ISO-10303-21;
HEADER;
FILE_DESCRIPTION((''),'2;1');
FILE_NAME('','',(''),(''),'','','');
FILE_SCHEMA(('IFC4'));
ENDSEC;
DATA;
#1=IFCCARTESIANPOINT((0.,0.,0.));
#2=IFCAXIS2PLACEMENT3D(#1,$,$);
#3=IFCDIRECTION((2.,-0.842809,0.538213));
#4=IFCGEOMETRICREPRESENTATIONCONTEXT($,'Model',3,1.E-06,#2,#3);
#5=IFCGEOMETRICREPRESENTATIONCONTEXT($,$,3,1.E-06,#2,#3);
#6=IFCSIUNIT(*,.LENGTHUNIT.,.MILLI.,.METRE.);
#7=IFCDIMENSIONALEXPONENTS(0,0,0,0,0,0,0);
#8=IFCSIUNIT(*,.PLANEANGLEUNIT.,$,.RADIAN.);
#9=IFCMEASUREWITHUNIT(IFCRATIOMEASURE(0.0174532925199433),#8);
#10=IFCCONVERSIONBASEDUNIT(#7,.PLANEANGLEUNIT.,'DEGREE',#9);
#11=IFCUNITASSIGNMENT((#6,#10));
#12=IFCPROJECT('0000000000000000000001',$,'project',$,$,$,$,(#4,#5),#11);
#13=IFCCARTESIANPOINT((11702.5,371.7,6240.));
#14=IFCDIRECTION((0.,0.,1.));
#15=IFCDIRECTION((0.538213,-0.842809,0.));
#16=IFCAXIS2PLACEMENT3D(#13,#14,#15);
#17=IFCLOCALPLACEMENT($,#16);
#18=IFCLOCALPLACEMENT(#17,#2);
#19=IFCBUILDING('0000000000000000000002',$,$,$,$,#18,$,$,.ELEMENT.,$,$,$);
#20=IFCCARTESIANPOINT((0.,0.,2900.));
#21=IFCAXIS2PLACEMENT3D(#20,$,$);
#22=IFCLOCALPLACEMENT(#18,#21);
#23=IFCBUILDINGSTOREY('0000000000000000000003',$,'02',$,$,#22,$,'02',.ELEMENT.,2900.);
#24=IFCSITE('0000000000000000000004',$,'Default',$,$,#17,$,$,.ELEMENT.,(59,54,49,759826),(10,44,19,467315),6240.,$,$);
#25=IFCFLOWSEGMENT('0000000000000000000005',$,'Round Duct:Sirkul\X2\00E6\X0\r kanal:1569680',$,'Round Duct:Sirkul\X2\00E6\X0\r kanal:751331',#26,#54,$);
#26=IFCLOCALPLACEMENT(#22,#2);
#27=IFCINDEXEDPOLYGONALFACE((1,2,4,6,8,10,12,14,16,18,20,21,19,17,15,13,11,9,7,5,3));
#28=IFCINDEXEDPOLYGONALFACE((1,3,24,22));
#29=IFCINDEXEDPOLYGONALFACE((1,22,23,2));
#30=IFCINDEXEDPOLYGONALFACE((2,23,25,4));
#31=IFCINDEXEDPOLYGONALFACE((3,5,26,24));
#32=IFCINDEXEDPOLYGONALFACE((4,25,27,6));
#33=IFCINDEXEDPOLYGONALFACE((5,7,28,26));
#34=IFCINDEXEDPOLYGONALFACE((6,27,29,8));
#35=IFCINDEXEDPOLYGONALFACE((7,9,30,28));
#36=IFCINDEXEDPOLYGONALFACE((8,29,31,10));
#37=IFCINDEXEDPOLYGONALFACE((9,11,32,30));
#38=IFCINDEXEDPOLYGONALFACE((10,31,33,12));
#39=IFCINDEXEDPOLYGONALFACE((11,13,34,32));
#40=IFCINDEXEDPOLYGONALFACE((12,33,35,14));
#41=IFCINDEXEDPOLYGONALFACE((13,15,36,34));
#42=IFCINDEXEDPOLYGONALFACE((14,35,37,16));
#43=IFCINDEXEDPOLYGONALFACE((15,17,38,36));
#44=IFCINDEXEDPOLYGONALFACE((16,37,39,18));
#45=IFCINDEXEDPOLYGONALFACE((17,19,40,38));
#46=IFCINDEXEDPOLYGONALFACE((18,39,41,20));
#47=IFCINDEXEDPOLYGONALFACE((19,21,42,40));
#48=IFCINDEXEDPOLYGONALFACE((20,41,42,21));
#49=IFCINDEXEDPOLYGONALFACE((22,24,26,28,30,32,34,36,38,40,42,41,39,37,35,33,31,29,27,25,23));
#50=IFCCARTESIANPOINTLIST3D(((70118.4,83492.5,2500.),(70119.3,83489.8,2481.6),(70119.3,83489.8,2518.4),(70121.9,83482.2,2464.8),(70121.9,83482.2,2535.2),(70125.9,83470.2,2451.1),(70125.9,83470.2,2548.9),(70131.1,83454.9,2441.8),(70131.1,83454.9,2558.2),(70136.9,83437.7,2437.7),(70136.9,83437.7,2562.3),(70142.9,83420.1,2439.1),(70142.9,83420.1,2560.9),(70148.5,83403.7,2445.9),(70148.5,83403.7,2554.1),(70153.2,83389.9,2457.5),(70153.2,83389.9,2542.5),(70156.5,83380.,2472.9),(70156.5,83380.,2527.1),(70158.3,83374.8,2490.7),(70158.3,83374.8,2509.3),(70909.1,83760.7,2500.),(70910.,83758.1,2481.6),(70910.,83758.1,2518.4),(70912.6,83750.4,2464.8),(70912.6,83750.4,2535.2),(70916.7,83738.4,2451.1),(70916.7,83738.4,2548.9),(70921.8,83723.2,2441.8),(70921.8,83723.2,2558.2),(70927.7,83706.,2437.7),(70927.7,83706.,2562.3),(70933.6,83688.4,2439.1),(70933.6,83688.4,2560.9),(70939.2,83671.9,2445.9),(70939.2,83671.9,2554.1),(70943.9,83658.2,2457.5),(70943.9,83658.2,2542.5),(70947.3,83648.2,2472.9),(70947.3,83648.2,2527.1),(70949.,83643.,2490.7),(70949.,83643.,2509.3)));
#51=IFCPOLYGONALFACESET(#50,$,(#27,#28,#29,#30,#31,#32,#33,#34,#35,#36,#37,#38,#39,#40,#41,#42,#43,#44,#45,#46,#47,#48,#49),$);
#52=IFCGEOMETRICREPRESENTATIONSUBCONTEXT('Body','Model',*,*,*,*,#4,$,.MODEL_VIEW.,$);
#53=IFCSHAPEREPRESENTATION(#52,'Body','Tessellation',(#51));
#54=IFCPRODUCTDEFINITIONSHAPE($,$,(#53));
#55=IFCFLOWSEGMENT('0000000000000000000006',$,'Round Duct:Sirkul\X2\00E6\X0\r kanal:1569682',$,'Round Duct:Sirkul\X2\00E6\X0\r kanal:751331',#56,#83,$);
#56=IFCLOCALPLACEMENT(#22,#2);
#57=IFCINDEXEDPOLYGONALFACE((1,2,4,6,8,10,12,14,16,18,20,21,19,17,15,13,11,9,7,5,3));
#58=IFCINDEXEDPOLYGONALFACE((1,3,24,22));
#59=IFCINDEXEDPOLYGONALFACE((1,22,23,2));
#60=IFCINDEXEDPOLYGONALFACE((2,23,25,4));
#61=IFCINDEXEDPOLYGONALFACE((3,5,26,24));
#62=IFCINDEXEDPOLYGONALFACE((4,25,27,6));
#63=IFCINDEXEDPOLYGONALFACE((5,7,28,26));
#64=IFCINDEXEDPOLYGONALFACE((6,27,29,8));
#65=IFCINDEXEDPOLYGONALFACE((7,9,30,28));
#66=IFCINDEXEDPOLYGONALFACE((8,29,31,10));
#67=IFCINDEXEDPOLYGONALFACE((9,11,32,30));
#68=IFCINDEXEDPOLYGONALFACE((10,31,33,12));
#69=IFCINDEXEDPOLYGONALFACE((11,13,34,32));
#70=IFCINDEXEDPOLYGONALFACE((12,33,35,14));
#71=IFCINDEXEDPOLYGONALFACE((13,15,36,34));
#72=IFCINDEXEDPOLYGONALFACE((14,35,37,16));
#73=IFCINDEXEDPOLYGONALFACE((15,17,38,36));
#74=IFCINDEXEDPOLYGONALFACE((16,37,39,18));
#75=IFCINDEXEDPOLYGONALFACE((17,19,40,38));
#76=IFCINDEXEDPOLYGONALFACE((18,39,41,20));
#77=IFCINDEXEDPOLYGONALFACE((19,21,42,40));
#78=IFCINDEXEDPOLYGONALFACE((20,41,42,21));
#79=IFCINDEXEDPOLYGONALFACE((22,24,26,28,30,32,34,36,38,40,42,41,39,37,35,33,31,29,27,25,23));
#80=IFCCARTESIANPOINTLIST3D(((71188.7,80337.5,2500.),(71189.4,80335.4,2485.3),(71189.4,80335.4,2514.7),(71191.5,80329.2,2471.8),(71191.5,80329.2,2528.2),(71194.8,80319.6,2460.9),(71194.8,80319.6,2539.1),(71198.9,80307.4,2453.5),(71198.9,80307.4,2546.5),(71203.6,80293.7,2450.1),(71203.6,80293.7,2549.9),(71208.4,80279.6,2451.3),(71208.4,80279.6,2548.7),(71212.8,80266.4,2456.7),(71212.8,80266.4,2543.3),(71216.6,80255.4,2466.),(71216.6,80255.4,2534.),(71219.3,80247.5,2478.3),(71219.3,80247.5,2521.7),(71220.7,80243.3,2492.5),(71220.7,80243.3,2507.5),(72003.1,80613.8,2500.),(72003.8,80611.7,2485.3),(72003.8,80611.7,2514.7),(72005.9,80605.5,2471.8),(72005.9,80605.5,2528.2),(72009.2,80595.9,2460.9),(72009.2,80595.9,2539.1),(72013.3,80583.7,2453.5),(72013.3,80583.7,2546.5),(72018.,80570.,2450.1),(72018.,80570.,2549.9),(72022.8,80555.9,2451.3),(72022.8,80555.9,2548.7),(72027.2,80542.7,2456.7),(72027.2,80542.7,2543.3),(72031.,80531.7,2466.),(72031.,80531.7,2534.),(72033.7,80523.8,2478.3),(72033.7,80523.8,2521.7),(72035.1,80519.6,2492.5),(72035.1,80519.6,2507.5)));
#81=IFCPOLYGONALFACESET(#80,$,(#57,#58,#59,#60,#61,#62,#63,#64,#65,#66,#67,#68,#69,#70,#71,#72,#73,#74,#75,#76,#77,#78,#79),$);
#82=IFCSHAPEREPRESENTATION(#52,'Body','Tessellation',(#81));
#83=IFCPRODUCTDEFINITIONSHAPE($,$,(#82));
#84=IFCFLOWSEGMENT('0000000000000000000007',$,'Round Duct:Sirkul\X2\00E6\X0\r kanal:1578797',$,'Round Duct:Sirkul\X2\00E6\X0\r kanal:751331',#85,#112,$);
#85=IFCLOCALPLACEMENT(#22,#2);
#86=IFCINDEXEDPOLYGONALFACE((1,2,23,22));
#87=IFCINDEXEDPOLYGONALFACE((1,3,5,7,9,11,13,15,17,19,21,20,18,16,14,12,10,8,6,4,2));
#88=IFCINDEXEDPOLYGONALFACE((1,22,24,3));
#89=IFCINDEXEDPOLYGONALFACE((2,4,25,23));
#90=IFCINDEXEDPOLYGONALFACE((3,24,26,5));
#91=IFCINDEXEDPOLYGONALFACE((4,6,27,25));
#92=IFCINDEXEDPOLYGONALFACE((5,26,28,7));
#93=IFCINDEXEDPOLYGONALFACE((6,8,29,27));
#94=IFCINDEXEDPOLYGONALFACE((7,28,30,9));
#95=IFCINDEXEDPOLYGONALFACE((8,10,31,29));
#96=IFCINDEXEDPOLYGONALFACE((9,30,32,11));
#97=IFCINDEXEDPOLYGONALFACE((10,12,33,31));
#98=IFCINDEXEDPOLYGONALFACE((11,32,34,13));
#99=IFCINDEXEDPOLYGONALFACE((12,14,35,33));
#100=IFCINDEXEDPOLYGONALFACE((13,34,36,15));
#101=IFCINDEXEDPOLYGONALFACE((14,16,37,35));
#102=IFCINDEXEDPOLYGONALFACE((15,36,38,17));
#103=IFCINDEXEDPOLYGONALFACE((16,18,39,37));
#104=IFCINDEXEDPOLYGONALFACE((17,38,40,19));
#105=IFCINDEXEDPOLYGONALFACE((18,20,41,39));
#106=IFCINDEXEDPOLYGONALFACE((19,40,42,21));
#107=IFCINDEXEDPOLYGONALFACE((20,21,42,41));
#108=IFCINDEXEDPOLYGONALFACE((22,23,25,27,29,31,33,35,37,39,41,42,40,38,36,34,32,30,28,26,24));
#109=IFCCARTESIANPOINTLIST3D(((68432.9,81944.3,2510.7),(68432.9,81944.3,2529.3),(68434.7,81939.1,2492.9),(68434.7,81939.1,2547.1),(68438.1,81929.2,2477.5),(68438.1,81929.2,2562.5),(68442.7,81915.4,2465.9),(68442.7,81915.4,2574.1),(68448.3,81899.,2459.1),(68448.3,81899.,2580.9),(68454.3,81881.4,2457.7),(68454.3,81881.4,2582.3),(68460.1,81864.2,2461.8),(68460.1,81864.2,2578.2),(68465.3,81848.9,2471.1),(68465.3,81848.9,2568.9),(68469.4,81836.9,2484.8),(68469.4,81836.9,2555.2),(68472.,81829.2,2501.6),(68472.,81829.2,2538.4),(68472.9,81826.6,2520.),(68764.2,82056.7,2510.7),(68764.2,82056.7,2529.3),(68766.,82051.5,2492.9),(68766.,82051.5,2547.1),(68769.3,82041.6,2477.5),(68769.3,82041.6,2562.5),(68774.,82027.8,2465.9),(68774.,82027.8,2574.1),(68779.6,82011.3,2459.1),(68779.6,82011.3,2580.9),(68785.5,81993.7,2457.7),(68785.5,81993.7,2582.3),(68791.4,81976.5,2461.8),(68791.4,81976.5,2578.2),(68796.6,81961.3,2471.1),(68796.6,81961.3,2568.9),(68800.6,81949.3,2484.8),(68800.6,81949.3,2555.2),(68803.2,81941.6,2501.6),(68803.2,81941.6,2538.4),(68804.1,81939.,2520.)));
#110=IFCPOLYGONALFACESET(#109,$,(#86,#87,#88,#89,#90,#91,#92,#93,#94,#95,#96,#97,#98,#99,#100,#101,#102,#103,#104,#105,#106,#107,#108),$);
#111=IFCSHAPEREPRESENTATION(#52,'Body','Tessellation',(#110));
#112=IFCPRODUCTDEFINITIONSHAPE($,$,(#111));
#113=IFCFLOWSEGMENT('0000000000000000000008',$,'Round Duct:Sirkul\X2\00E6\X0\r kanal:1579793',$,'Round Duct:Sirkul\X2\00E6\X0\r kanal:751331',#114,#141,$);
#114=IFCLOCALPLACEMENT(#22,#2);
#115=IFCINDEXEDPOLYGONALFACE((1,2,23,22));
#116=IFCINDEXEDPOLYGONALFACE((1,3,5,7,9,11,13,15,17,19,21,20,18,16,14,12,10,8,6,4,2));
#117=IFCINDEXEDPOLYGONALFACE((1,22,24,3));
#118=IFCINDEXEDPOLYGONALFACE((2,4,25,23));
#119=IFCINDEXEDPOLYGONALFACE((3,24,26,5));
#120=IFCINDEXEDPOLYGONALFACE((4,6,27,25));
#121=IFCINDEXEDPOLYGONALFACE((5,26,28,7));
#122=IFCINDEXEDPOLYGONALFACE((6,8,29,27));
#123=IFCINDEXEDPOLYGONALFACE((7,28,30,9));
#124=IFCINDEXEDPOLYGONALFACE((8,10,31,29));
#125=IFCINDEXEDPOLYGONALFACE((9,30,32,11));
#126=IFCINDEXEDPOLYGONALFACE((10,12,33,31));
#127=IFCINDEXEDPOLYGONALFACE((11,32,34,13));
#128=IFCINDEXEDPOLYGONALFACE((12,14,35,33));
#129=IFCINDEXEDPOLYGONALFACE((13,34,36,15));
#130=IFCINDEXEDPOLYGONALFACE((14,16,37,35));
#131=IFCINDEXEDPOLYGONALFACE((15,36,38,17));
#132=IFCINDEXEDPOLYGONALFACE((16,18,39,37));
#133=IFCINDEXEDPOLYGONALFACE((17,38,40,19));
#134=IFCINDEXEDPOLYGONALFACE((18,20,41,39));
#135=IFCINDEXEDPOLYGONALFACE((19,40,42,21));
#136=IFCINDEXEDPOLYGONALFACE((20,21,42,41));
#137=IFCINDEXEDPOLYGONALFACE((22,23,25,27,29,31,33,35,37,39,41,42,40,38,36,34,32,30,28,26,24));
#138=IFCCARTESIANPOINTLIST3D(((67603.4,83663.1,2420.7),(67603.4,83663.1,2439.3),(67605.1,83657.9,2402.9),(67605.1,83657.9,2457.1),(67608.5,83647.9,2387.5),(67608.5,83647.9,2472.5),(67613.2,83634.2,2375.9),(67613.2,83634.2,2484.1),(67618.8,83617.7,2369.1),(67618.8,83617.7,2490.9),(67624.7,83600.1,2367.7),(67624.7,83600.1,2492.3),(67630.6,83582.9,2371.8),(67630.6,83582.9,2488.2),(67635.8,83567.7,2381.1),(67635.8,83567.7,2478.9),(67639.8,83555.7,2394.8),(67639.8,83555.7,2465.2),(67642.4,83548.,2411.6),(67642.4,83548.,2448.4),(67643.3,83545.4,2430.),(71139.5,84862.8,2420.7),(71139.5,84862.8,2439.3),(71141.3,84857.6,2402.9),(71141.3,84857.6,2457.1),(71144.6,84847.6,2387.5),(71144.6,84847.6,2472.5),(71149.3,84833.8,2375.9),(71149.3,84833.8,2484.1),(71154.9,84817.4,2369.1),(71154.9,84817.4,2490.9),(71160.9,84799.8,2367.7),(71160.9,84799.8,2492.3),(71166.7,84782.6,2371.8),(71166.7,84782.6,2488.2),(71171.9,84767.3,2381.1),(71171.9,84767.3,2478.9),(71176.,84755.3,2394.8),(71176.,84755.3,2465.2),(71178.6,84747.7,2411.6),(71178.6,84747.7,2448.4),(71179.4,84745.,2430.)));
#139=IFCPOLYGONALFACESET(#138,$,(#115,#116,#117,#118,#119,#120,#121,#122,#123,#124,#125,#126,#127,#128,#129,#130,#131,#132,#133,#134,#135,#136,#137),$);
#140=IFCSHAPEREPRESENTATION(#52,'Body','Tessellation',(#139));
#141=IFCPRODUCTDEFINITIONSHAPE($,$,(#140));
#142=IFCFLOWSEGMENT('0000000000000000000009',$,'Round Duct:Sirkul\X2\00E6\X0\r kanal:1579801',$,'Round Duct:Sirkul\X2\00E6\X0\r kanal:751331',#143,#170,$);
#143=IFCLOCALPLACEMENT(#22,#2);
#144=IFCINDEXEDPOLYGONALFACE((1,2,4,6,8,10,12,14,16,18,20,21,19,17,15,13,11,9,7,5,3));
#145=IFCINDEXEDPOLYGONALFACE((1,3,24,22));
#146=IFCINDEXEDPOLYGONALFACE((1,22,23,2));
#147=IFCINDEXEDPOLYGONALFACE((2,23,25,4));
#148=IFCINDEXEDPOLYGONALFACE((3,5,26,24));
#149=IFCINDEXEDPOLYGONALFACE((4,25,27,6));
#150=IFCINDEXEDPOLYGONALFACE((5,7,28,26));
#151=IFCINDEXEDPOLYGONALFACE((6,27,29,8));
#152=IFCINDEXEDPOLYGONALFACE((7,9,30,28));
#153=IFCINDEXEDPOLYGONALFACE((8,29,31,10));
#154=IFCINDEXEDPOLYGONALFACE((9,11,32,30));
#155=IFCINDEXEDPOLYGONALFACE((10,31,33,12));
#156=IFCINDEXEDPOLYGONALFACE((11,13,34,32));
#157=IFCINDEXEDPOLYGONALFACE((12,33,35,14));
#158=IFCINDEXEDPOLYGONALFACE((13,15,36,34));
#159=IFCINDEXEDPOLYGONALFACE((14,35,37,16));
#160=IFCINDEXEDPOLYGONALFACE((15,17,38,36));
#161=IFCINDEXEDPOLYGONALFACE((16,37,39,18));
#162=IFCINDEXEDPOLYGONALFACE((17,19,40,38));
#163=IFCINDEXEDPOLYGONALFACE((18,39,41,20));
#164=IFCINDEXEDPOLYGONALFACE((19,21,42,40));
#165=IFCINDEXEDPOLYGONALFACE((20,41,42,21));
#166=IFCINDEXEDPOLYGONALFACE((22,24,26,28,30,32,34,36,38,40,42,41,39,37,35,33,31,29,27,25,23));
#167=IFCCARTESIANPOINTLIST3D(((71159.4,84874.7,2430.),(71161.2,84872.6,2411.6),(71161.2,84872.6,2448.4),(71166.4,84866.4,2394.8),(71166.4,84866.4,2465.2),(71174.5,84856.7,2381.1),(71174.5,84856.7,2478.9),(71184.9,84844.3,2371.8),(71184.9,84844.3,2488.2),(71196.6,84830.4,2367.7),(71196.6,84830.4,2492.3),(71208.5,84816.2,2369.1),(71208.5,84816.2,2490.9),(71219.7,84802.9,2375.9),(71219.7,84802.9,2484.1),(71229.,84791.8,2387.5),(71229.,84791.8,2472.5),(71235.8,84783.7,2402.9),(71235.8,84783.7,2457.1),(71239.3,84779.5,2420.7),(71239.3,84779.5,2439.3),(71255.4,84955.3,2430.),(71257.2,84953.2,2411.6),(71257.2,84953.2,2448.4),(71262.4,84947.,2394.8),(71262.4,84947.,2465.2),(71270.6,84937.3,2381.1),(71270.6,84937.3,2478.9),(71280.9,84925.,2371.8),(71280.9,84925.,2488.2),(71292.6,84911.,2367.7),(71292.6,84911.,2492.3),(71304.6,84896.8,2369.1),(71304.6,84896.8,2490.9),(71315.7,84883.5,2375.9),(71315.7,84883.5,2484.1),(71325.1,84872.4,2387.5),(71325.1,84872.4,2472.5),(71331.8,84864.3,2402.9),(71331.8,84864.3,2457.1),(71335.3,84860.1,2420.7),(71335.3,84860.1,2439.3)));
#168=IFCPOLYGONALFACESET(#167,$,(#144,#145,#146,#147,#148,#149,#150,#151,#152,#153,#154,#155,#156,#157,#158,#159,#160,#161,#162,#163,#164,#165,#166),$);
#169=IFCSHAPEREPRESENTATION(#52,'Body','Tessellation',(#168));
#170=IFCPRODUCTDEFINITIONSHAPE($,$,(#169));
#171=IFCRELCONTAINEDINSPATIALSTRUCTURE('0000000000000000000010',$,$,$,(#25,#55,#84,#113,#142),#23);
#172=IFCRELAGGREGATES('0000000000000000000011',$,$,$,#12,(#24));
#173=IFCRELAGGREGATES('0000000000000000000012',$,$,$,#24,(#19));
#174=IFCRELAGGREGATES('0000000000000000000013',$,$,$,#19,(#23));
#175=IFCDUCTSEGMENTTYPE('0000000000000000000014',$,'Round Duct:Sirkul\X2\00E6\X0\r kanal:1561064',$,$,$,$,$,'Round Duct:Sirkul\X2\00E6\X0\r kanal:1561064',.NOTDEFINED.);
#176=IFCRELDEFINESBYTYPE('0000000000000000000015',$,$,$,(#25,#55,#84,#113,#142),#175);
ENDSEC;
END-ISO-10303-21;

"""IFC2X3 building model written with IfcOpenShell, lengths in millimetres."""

from ifc_helpers import new_model, entity, si_unit, converted_unit, direction, frame, frame_2d, origin, origin_2d_with_axis, place, context, subcontext, project, spatial, circle, extrude, type_object, element, save


model = new_model("IFC2X3")

# Units and contexts
model_context = context("Model", 3, precision=1e-06, world=origin(), true_north=direction((2.0, -0.842809, 0.538213)))
context_of_model = context(None, 3, precision=1e-06, world=origin(), true_north=direction((2.0, -0.842809, 0.538213)))
body_context = subcontext(model_context, "Body", "Model", "MODEL_VIEW")
ifc_project = project(units=[si_unit("LENGTHUNIT", "METRE", prefix="MILLI"), converted_unit("PLANEANGLEUNIT", "DEGREE", entity("IfcRatioMeasure", 0.0174532925199433), si_unit("PLANEANGLEUNIT", "RADIAN"), dimensions=[0, 0, 0, 0, 0, 0, 0])], contexts=[model_context, context_of_model])

# Site, building, storey
site_placement = place(None, frame((11702.5, 371.7, 6240.0), z_axis=(0.0, 0.0, 1.0), x_axis=(0.538213, -0.842809, 0.0)))
site = spatial("IfcSite", under=ifc_project, at=site_placement, Name="Default", CompositionType="ELEMENT", RefLatitude=(59, 54, 49, 759826), RefLongitude=(10, 44, 19, 467315), RefElevation=6240.0)
building_placement = place(site_placement, origin())
building = spatial("IfcBuilding", under=site, at=building_placement, CompositionType="ELEMENT")
storey_placement = place(building_placement, frame((0.0, 0.0, 2900.0)))
storey = spatial("IfcBuildingStorey", under=building, at=storey_placement, Name="02", LongName="02", CompositionType="ELEMENT", Elevation=2900.0)

# Flow segments
duct_segment_type = type_object("IfcDuctSegmentType", Name="Round Duct:Sirkulær kanal:1561064", ElementType="Round Duct:Sirkulær kanal:1561064", PredefinedType="NOTDEFINED")
flow_segment_1_placement = place(storey_placement, origin())
element("IfcFlowSegment", 1, at=flow_segment_1_placement, inside=storey, type_object=duct_segment_type, Name="Round Duct:Sirkulær kanal:1569680", ObjectType="Round Duct:Sirkulær kanal:751331", context=body_context, shape_type="SweptSolid", body=[
    extrude(circle(Radius=62.5, at=origin_2d_with_axis()), frame((70138.4, 83433.3, 2500.0), z_axis=(0.946986, 0.321274, 0.0), x_axis=(-0.321274, 0.946986, 0.0)), (0.0, 0.0, 1.0), 835.0),
])
flow_segment_2_placement = place(storey_placement, origin())
element("IfcFlowSegment", 2, at=flow_segment_2_placement, inside=storey, type_object=duct_segment_type, Name="Round Duct:Sirkulær kanal:1569682", ObjectType="Round Duct:Sirkulær kanal:751331", context=body_context, shape_type="SweptSolid", body=[
    extrude(circle(Radius=50.0, at=origin_2d_with_axis()), frame((71204.8, 80290.1, 2500.0), z_axis=(0.946986, 0.321274, 0.0), x_axis=(-0.321274, 0.946986, 0.0)), (0.0, 0.0, 1.0), 860.0),
])
flow_segment_3_placement = place(storey_placement, origin())
element("IfcFlowSegment", 3, at=flow_segment_3_placement, inside=storey, type_object=duct_segment_type, Name="Round Duct:Sirkulær kanal:1578797", ObjectType="Round Duct:Sirkulær kanal:751331", context=body_context, shape_type="SweptSolid", body=[
    extrude(circle(Radius=62.5, at=origin_2d_with_axis()), frame((68452.8, 81885.8, 2520.0), z_axis=(0.946986, 0.321274, 0.0), x_axis=(0.321274, -0.946986, 0.0)), (0.0, 0.0, 1.0), 349.8),
])
flow_segment_4_placement = place(storey_placement, origin())
element("IfcFlowSegment", 4, at=flow_segment_4_placement, inside=storey, type_object=duct_segment_type, Name="Round Duct:Sirkulær kanal:1579793", ObjectType="Round Duct:Sirkulær kanal:751331", context=body_context, shape_type="SweptSolid", body=[
    extrude(circle(Radius=62.5, at=origin_2d_with_axis()), frame((67623.2, 83604.6, 2430.0), z_axis=(0.946986, 0.321274, 0.0), x_axis=(0.321274, -0.946986, 0.0)), (0.0, 0.0, 1.0), 3734.1),
])
flow_segment_5_placement = place(storey_placement, origin())
element("IfcFlowSegment", 5, at=flow_segment_5_placement, inside=storey, type_object=duct_segment_type, Name="Round Duct:Sirkulær kanal:1579801", ObjectType="Round Duct:Sirkulær kanal:751331", context=body_context, shape_type="SweptSolid", body=[
    extrude(circle(Radius=62.5, at=frame_2d((0.0, 0.0), x_axis=(1.0, 0.0))), frame((71199.6, 84826.9, 2430.0), z_axis=(0.765966, 0.642881, 0.0), x_axis=(-0.642881, 0.765966, 0.0)), (0.0, 0.0, 1.0), 125.4),
])

save(model, "model.ifc")
